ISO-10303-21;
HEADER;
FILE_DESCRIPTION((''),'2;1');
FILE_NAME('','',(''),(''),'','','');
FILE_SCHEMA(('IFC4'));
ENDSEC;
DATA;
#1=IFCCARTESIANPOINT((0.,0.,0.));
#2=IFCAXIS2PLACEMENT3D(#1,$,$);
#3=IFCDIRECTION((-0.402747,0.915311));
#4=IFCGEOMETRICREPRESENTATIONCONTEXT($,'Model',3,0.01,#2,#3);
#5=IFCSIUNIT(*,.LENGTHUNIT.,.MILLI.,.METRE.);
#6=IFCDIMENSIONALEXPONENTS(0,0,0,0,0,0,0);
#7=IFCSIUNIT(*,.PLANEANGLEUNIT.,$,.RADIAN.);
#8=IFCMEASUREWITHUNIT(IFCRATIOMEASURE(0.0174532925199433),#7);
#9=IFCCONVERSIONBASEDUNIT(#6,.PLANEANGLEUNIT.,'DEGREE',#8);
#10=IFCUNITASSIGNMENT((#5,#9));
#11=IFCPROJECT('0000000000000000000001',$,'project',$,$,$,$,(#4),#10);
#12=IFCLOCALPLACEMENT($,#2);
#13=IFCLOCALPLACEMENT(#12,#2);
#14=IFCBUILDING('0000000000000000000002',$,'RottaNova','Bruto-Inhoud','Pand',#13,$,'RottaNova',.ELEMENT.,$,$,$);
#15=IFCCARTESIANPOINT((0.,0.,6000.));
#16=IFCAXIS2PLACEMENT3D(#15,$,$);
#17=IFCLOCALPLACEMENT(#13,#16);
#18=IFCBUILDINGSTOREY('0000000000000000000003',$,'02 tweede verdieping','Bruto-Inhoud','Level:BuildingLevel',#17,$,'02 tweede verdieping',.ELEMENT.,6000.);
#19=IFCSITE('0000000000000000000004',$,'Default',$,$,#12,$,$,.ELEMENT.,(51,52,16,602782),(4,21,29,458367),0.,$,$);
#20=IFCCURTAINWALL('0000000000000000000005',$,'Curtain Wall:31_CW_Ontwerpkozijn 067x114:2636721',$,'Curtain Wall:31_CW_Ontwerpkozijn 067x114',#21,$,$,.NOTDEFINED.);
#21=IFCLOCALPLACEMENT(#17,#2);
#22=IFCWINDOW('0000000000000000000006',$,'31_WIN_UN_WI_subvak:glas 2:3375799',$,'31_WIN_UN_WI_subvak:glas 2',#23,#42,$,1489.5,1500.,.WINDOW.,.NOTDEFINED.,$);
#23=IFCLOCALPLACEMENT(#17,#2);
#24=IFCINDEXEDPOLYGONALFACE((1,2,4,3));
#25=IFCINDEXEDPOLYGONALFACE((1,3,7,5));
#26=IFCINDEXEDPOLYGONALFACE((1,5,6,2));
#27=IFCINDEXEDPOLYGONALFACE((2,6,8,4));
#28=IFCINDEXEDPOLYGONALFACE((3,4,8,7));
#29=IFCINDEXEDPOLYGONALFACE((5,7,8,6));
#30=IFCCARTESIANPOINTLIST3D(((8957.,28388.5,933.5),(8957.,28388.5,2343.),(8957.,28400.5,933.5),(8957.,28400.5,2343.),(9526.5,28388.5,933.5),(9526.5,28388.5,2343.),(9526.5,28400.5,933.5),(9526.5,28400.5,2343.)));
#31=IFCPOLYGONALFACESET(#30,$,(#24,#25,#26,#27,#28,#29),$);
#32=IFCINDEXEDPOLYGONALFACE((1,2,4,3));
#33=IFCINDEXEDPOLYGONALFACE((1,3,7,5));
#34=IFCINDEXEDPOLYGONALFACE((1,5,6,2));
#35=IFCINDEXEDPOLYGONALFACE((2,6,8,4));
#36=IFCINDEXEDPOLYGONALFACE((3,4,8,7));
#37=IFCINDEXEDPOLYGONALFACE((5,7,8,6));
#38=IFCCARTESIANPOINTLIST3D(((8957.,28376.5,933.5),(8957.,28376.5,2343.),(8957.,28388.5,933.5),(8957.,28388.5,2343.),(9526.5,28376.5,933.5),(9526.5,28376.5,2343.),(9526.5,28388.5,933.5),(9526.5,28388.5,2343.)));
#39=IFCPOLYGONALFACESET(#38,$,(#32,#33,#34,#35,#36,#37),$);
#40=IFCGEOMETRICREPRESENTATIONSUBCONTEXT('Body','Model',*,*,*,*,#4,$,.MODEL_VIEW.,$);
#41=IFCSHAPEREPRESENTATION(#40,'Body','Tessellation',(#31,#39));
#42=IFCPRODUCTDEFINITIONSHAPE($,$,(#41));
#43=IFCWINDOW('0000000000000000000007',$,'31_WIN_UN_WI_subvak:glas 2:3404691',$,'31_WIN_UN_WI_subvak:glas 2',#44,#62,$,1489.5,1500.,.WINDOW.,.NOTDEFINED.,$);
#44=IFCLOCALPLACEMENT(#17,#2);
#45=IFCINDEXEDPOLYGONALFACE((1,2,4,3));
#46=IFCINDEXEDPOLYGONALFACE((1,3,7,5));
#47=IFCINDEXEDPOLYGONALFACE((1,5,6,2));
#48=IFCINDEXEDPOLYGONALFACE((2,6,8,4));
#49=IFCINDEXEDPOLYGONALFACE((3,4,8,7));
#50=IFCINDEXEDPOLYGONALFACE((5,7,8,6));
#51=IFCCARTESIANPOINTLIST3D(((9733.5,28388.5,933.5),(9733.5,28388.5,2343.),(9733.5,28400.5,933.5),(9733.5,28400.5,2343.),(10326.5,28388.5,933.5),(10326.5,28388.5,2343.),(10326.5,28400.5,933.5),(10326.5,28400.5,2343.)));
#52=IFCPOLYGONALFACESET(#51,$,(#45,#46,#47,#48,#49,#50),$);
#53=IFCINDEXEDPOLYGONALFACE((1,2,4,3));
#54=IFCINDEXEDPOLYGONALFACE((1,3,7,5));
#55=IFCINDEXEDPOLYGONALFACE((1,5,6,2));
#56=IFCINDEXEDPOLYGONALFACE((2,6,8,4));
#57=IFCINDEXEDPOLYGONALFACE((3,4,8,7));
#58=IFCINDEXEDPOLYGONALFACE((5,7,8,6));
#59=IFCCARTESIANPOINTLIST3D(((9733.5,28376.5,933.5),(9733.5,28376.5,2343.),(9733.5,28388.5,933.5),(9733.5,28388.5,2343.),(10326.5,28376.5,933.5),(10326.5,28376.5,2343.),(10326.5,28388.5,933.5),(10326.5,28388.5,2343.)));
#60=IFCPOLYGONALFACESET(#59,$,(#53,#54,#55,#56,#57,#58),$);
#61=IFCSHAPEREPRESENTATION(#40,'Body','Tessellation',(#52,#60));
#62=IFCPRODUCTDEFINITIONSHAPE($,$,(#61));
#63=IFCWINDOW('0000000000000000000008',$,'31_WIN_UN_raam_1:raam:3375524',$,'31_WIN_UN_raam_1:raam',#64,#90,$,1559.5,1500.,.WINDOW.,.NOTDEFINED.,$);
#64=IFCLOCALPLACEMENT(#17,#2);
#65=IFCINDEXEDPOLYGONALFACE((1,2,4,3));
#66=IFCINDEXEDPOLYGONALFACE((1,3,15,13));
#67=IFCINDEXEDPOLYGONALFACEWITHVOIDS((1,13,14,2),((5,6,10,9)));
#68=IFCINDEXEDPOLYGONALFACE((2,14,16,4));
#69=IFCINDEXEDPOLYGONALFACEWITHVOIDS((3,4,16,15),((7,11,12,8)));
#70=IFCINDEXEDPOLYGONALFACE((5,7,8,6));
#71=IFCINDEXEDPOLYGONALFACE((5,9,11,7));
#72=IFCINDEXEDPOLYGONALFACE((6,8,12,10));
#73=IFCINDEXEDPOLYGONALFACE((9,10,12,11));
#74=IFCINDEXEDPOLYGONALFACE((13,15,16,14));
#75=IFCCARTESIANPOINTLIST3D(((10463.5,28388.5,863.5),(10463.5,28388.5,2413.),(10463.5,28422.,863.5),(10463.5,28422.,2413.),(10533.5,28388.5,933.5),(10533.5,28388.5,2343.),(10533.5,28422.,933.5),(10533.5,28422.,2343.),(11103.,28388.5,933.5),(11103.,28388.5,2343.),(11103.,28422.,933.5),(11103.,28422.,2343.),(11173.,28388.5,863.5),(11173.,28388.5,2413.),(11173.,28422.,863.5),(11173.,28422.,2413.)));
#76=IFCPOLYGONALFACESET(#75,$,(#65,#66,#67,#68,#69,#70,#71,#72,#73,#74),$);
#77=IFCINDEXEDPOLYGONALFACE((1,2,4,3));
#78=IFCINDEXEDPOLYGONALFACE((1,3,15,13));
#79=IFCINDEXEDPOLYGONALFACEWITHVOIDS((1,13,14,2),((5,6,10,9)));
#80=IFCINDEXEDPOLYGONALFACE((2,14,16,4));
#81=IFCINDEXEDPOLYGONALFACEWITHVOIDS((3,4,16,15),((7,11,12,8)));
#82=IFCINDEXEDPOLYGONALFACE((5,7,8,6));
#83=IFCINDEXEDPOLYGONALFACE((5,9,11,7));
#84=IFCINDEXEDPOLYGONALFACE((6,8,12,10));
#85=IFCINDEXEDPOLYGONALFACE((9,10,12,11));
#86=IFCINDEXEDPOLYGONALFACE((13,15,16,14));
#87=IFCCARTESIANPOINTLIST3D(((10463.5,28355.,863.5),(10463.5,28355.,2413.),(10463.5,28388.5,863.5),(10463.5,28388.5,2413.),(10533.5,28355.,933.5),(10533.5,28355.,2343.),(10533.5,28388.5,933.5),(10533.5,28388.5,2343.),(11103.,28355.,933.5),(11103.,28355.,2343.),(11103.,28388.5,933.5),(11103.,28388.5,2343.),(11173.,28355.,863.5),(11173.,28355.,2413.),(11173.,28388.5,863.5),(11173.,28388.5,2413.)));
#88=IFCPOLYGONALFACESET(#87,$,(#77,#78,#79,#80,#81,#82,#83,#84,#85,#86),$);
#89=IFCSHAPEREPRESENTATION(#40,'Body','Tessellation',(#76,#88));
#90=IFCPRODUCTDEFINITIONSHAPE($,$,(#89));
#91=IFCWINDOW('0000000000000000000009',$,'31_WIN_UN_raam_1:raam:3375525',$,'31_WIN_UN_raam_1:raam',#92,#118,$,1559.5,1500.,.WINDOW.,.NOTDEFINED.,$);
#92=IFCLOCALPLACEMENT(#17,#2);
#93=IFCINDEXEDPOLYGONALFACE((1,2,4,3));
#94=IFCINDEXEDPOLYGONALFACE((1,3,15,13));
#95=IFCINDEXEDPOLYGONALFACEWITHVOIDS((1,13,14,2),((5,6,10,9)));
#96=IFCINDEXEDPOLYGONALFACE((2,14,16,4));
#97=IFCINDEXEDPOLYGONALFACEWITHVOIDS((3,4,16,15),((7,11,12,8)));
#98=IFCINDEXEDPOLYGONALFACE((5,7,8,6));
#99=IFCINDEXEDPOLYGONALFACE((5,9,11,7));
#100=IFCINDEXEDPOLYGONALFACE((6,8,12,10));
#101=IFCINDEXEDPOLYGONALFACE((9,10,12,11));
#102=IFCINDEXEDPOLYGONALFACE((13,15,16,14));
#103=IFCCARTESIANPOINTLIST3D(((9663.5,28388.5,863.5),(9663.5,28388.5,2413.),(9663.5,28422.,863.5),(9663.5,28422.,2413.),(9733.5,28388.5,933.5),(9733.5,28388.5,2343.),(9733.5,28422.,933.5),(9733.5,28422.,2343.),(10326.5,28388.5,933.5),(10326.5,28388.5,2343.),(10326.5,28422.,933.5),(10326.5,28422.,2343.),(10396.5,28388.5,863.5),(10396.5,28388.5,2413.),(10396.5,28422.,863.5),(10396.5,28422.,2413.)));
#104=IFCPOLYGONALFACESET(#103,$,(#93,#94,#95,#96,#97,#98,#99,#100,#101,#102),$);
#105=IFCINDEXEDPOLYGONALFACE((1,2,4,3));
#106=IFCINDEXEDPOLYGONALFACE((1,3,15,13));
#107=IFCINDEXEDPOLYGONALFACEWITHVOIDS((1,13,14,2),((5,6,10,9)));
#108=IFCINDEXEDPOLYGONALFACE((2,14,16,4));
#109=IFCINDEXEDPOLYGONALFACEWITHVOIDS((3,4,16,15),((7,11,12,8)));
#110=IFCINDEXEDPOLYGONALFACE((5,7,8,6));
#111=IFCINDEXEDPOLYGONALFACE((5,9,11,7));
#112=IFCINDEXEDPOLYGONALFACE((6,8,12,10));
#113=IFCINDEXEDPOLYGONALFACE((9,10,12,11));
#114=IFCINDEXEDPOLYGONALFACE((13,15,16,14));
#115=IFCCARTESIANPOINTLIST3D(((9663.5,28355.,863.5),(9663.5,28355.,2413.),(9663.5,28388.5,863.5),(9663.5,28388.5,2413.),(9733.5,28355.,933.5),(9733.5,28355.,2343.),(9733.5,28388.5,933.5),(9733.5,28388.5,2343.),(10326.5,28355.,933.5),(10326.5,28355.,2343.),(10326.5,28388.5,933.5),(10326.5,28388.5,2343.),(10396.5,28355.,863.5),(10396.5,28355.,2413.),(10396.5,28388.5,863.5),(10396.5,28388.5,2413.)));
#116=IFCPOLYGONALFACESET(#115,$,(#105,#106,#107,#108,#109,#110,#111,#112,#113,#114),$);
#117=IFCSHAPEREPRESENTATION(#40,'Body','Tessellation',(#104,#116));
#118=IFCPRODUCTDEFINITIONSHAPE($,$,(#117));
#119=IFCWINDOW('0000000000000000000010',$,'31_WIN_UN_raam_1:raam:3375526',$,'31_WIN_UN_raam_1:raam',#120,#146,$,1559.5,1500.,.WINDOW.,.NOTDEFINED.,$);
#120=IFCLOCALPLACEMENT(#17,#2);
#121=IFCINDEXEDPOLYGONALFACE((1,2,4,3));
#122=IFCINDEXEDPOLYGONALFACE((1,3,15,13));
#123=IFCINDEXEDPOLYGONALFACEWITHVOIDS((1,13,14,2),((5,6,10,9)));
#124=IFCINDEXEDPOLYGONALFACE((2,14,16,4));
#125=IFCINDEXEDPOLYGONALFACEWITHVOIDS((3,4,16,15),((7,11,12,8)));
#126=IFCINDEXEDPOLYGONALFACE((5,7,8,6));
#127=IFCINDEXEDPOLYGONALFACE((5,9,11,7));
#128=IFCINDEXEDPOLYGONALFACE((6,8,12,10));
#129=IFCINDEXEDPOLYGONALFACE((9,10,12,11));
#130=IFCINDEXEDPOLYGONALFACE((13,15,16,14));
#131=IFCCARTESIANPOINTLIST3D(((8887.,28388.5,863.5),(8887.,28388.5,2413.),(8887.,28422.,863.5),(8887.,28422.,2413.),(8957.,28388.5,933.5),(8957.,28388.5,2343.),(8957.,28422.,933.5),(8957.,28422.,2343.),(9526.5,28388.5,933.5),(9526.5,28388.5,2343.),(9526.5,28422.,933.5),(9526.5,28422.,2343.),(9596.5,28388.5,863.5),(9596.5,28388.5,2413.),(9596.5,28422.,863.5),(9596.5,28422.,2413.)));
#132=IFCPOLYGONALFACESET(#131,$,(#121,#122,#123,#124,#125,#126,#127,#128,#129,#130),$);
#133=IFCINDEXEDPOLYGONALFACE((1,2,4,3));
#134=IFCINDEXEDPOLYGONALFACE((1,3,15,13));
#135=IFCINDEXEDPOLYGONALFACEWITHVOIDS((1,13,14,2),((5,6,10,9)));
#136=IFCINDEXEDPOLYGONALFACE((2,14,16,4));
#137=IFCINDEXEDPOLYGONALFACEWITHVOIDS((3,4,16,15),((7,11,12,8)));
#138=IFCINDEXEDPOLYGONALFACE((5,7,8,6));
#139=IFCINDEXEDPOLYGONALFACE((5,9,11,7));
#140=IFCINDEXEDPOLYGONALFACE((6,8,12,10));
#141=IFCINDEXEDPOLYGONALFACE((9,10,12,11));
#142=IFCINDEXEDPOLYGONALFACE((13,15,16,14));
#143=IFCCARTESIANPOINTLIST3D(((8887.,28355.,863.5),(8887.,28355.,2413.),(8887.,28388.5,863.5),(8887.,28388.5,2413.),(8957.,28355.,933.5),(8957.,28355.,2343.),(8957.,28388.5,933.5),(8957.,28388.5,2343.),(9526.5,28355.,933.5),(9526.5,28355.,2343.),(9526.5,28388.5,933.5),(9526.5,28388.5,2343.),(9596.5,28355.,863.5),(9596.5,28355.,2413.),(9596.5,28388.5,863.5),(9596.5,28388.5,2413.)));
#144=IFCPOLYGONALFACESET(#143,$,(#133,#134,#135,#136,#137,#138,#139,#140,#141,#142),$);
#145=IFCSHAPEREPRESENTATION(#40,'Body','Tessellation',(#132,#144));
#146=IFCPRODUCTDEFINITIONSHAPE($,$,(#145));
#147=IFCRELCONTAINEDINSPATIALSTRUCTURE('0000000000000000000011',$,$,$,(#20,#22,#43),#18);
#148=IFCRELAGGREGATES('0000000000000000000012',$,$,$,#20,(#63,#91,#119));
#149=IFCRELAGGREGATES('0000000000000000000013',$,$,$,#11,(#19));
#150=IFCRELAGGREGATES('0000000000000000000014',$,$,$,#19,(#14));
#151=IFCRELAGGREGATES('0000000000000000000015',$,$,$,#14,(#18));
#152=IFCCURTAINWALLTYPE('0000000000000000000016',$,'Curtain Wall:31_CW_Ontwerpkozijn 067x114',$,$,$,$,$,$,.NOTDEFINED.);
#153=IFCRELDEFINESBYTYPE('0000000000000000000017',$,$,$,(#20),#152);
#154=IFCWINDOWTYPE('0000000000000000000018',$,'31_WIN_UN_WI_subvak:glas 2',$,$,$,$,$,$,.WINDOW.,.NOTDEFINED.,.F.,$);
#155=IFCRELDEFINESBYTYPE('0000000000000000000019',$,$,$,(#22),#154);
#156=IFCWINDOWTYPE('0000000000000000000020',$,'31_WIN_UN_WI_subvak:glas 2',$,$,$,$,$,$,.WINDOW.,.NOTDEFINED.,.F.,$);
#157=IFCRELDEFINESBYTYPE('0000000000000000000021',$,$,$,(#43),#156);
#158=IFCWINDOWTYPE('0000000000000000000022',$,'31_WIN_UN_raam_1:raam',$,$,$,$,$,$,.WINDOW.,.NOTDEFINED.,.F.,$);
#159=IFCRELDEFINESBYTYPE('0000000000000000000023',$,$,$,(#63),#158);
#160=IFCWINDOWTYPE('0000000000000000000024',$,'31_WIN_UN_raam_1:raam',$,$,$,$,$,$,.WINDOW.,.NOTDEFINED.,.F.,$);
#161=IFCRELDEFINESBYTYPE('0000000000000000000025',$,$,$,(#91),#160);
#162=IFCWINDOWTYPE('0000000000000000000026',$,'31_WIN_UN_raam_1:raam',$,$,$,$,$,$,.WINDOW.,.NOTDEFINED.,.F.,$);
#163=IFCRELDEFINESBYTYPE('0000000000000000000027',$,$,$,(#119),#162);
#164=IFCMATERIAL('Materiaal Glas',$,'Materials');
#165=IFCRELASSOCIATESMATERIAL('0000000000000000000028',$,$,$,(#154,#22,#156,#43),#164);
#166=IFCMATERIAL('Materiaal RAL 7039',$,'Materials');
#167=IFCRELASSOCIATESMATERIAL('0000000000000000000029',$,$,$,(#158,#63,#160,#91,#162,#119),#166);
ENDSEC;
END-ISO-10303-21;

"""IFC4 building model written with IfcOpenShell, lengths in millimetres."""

from ifc_helpers import new_model, entity, si_unit, converted_unit, direction, frame, origin, origin_2d_with_axis, place, context, subcontext, project, spatial, polyline, rectangle, outline, extrude, source, transform, mapped, material, type_object, type_shapes, element, aggregate, save


model = new_model("IFC4")

# Units and contexts
model_context = context("Model", 3, precision=0.01, world=origin(), true_north=direction((-0.402747, 0.915311)))
body_context = subcontext(model_context, "Body", "Model", "MODEL_VIEW")
ifc_project = project(units=[si_unit("LENGTHUNIT", "METRE", prefix="MILLI"), converted_unit("PLANEANGLEUNIT", "DEGREE", entity("IfcRatioMeasure", 0.0174532925199433), si_unit("PLANEANGLEUNIT", "RADIAN"), dimensions=[0, 0, 0, 0, 0, 0, 0])], contexts=[model_context])

# Site, building, storey
site_placement = place(None, origin())
site = spatial("IfcSite", under=ifc_project, at=site_placement, Name="Default", CompositionType="ELEMENT", RefLatitude=(51, 52, 16, 602782), RefLongitude=(4, 21, 29, 458367), RefElevation=0.0)
building_placement = place(site_placement, origin())
building = spatial("IfcBuilding", under=site, at=building_placement, Name="RottaNova", Description="Bruto-Inhoud", ObjectType="Pand", LongName="RottaNova", CompositionType="ELEMENT")
storey_placement = place(building_placement, frame((0.0, 0.0, 6000.0)))
storey = spatial("IfcBuildingStorey", under=building, at=storey_placement, Name="02 tweede verdieping", Description="Bruto-Inhoud", ObjectType="Level:BuildingLevel", LongName="02 tweede verdieping", CompositionType="ELEMENT", Elevation=6000.0)

# Curtain wall
curtain_wall_type = type_object("IfcCurtainWallType", Name="Curtain Wall:31_CW_Ontwerpkozijn 067x114", PredefinedType="NOTDEFINED")
curtain_wall_placement = place(storey_placement, frame((0.0, 0.0, -6000.0)))
curtain_wall = element("IfcCurtainWall", 1, at=curtain_wall_placement, inside=storey, type_object=curtain_wall_type, Name="Curtain Wall:31_CW_Ontwerpkozijn 067x114:2636721", ObjectType="Curtain Wall:31_CW_Ontwerpkozijn 067x114", PredefinedType="NOTDEFINED")
ifc_material_1 = material(Name="Materiaal Glas", Category="Materials")

# Windows
window_type_1 = type_object("IfcWindowType", Name="31_WIN_UN_WI_subvak:glas 2", ParameterTakesPrecedence=False, PartitioningType="NOTDEFINED", PredefinedType="WINDOW", material=ifc_material_1)
shared_shape_1 = source(origin(), body_context, "Body", "SweptSolid", [
    extrude(rectangle(XDim=569.5, YDim=12.0, at=origin_2d_with_axis()), frame((0.0, -6.0, 0.0)), (0.0, 0.0, 1.0), 1409.5),
    extrude(rectangle(XDim=569.5, YDim=12.0, at=origin_2d_with_axis()), frame((0.0, 6.0, 0.0)), (0.0, 0.0, 1.0), 1409.5),
])
type_shapes(window_type_1, [shared_shape_1])
for number, where, z_axis, x_axis, name in (
    (2, (9241.7, 28388.5, 933.5), (0.0, 0.0, 1.0), (-1.0, 0.0, 0.0), "31_WIN_UN_WI_subvak:glas 2:3375799"),
):
    element("IfcWindow", number, at=place(storey_placement, frame(where, z_axis=z_axis, x_axis=x_axis)), inside=storey, type_object=window_type_1, material=ifc_material_1, Name=name, ObjectType="31_WIN_UN_WI_subvak:glas 2", OverallHeight=1489.5, OverallWidth=1500.0, PartitioningType="NOTDEFINED", PredefinedType="WINDOW", context=body_context, shape_type="MappedRepresentation", body=[
        mapped(shared_shape_1, transform((0.0, 0.0, 0.0), scale=1.0)),
    ])
window_type_2 = type_object("IfcWindowType", Name="31_WIN_UN_WI_subvak:glas 2", ParameterTakesPrecedence=False, PartitioningType="NOTDEFINED", PredefinedType="WINDOW", material=ifc_material_1)
shared_shape_2 = source(origin(), body_context, "Body", "SweptSolid", [
    extrude(rectangle(XDim=593.0, YDim=12.0, at=origin_2d_with_axis()), frame((0.0, -6.0, 0.0)), (0.0, 0.0, 1.0), 1409.5),
    extrude(rectangle(XDim=593.0, YDim=12.0, at=origin_2d_with_axis()), frame((0.0, 6.0, 0.0)), (0.0, 0.0, 1.0), 1409.5),
])
type_shapes(window_type_2, [shared_shape_2])
window_1_placement = place(storey_placement, frame((10030.0, 28388.5, 933.5), z_axis=(0.0, 0.0, 1.0), x_axis=(-1.0, 0.0, 0.0)))
element("IfcWindow", 3, at=window_1_placement, inside=storey, type_object=window_type_2, material=ifc_material_1, Name="31_WIN_UN_WI_subvak:glas 2:3404691", ObjectType="31_WIN_UN_WI_subvak:glas 2", OverallHeight=1489.5, OverallWidth=1500.0, PartitioningType="NOTDEFINED", PredefinedType="WINDOW", context=body_context, shape_type="MappedRepresentation", body=[
    mapped(shared_shape_2, transform((0.0, 0.0, 0.0), scale=1.0)),
])

# Windows
ifc_material_2 = material(Name="Materiaal RAL 7039", Category="Materials")
window_type_3 = type_object("IfcWindowType", Name="31_WIN_UN_raam_1:raam", ParameterTakesPrecedence=False, PartitioningType="NOTDEFINED", PredefinedType="WINDOW", material=ifc_material_2)
shared_shape_3 = source(origin(), body_context, "Body", "SweptSolid", [
    extrude(outline(polyline([(-354.7, -774.7), (354.7, -774.7), (354.7, 774.7), (-354.7, 774.7), (-354.7, -774.7)]), holes=[polyline([(-284.7, 704.7), (284.7, 704.7), (284.7, -704.8), (-284.7, -704.8), (-284.7, 704.7)])]), frame((0.0, 92.0, 774.8), z_axis=(0.0, -1.0, 0.0), x_axis=(-1.0, 0.0, 0.0)), (0.0, 0.0, 1.0), 33.5),
    extrude(outline(polyline([(-354.7, -774.7), (354.7, -774.7), (354.7, 774.7), (-354.7, 774.7), (-354.7, -774.7)]), holes=[polyline([(-284.7, 704.7), (284.7, 704.7), (284.7, -704.8), (-284.7, -704.8), (-284.7, 704.7)])]), frame((0.0, 58.5, 774.8), z_axis=(0.0, -1.0, 0.0), x_axis=(-1.0, 0.0, 0.0)), (0.0, 0.0, 1.0), 33.5),
])
type_shapes(window_type_3, [shared_shape_3])
window_2_placement = place(curtain_wall_placement, frame((10818.2, 28330.0, 6863.5)))
window_2 = element("IfcWindow", 4, at=window_2_placement, type_object=window_type_3, material=ifc_material_2, Name="31_WIN_UN_raam_1:raam:3375524", ObjectType="31_WIN_UN_raam_1:raam", OverallHeight=1559.5, OverallWidth=1500.0, PartitioningType="NOTDEFINED", PredefinedType="WINDOW", context=body_context, shape_type="MappedRepresentation", body=[
    mapped(shared_shape_3, transform((0.0, 0.0, 0.0), scale=1.0)),
])
window_type_4 = type_object("IfcWindowType", Name="31_WIN_UN_raam_1:raam", ParameterTakesPrecedence=False, PartitioningType="NOTDEFINED", PredefinedType="WINDOW", material=ifc_material_2)
shared_shape_4 = source(origin(), body_context, "Body", "SweptSolid", [
    extrude(outline(polyline([(-366.5, -774.7), (366.5, -774.7), (366.5, 774.7), (-366.5, 774.7), (-366.5, -774.7)]), holes=[polyline([(-296.5, 704.7), (296.5, 704.7), (296.5, -704.8), (-296.5, -704.8), (-296.5, 704.7)])]), frame((0.0, 92.0, 774.8), z_axis=(0.0, -1.0, 0.0), x_axis=(-1.0, 0.0, 0.0)), (0.0, 0.0, 1.0), 33.5),
    extrude(outline(polyline([(-366.5, -774.7), (366.5, -774.7), (366.5, 774.7), (-366.5, 774.7), (-366.5, -774.7)]), holes=[polyline([(-296.5, 704.7), (296.5, 704.7), (296.5, -704.8), (-296.5, -704.8), (-296.5, 704.7)])]), frame((0.0, 58.5, 774.8), z_axis=(0.0, -1.0, 0.0), x_axis=(-1.0, 0.0, 0.0)), (0.0, 0.0, 1.0), 33.5),
])
type_shapes(window_type_4, [shared_shape_4])
window_3_placement = place(curtain_wall_placement, frame((10030.0, 28330.0, 6863.5)))
window_3 = element("IfcWindow", 5, at=window_3_placement, type_object=window_type_4, material=ifc_material_2, Name="31_WIN_UN_raam_1:raam:3375525", ObjectType="31_WIN_UN_raam_1:raam", OverallHeight=1559.5, OverallWidth=1500.0, PartitioningType="NOTDEFINED", PredefinedType="WINDOW", context=body_context, shape_type="MappedRepresentation", body=[
    mapped(shared_shape_4, transform((0.0, 0.0, 0.0), scale=1.0)),
])
window_type_5 = type_object("IfcWindowType", Name="31_WIN_UN_raam_1:raam", ParameterTakesPrecedence=False, PartitioningType="NOTDEFINED", PredefinedType="WINDOW", material=ifc_material_2)
shared_shape_5 = source(origin(), body_context, "Body", "SweptSolid", [
    extrude(outline(polyline([(-354.7, -774.7), (354.7, -774.7), (354.7, 774.7), (-354.7, 774.7), (-354.7, -774.7)]), holes=[polyline([(-284.7, 704.7), (284.7, 704.7), (284.7, -704.8), (-284.7, -704.8), (-284.7, 704.7)])]), frame((0.0, 92.0, 774.8), z_axis=(0.0, -1.0, 0.0), x_axis=(-1.0, 0.0, 0.0)), (0.0, 0.0, 1.0), 33.5),
    extrude(outline(polyline([(-354.7, -774.7), (354.7, -774.7), (354.7, 774.7), (-354.7, 774.7), (-354.7, -774.7)]), holes=[polyline([(-284.7, 704.7), (284.7, 704.7), (284.7, -704.8), (-284.7, -704.8), (-284.7, 704.7)])]), frame((0.0, 58.5, 774.8), z_axis=(0.0, -1.0, 0.0), x_axis=(-1.0, 0.0, 0.0)), (0.0, 0.0, 1.0), 33.5),
])
type_shapes(window_type_5, [shared_shape_5])
window_4_placement = place(curtain_wall_placement, frame((9241.7, 28330.0, 6863.5)))
window_4 = element("IfcWindow", 6, at=window_4_placement, type_object=window_type_5, material=ifc_material_2, Name="31_WIN_UN_raam_1:raam:3375526", ObjectType="31_WIN_UN_raam_1:raam", OverallHeight=1559.5, OverallWidth=1500.0, PartitioningType="NOTDEFINED", PredefinedType="WINDOW", context=body_context, shape_type="MappedRepresentation", body=[
    mapped(shared_shape_5, transform((0.0, 0.0, 0.0), scale=1.0)),
])
aggregate(curtain_wall, [window_2, window_3, window_4])

save(model, "model.ifc")
